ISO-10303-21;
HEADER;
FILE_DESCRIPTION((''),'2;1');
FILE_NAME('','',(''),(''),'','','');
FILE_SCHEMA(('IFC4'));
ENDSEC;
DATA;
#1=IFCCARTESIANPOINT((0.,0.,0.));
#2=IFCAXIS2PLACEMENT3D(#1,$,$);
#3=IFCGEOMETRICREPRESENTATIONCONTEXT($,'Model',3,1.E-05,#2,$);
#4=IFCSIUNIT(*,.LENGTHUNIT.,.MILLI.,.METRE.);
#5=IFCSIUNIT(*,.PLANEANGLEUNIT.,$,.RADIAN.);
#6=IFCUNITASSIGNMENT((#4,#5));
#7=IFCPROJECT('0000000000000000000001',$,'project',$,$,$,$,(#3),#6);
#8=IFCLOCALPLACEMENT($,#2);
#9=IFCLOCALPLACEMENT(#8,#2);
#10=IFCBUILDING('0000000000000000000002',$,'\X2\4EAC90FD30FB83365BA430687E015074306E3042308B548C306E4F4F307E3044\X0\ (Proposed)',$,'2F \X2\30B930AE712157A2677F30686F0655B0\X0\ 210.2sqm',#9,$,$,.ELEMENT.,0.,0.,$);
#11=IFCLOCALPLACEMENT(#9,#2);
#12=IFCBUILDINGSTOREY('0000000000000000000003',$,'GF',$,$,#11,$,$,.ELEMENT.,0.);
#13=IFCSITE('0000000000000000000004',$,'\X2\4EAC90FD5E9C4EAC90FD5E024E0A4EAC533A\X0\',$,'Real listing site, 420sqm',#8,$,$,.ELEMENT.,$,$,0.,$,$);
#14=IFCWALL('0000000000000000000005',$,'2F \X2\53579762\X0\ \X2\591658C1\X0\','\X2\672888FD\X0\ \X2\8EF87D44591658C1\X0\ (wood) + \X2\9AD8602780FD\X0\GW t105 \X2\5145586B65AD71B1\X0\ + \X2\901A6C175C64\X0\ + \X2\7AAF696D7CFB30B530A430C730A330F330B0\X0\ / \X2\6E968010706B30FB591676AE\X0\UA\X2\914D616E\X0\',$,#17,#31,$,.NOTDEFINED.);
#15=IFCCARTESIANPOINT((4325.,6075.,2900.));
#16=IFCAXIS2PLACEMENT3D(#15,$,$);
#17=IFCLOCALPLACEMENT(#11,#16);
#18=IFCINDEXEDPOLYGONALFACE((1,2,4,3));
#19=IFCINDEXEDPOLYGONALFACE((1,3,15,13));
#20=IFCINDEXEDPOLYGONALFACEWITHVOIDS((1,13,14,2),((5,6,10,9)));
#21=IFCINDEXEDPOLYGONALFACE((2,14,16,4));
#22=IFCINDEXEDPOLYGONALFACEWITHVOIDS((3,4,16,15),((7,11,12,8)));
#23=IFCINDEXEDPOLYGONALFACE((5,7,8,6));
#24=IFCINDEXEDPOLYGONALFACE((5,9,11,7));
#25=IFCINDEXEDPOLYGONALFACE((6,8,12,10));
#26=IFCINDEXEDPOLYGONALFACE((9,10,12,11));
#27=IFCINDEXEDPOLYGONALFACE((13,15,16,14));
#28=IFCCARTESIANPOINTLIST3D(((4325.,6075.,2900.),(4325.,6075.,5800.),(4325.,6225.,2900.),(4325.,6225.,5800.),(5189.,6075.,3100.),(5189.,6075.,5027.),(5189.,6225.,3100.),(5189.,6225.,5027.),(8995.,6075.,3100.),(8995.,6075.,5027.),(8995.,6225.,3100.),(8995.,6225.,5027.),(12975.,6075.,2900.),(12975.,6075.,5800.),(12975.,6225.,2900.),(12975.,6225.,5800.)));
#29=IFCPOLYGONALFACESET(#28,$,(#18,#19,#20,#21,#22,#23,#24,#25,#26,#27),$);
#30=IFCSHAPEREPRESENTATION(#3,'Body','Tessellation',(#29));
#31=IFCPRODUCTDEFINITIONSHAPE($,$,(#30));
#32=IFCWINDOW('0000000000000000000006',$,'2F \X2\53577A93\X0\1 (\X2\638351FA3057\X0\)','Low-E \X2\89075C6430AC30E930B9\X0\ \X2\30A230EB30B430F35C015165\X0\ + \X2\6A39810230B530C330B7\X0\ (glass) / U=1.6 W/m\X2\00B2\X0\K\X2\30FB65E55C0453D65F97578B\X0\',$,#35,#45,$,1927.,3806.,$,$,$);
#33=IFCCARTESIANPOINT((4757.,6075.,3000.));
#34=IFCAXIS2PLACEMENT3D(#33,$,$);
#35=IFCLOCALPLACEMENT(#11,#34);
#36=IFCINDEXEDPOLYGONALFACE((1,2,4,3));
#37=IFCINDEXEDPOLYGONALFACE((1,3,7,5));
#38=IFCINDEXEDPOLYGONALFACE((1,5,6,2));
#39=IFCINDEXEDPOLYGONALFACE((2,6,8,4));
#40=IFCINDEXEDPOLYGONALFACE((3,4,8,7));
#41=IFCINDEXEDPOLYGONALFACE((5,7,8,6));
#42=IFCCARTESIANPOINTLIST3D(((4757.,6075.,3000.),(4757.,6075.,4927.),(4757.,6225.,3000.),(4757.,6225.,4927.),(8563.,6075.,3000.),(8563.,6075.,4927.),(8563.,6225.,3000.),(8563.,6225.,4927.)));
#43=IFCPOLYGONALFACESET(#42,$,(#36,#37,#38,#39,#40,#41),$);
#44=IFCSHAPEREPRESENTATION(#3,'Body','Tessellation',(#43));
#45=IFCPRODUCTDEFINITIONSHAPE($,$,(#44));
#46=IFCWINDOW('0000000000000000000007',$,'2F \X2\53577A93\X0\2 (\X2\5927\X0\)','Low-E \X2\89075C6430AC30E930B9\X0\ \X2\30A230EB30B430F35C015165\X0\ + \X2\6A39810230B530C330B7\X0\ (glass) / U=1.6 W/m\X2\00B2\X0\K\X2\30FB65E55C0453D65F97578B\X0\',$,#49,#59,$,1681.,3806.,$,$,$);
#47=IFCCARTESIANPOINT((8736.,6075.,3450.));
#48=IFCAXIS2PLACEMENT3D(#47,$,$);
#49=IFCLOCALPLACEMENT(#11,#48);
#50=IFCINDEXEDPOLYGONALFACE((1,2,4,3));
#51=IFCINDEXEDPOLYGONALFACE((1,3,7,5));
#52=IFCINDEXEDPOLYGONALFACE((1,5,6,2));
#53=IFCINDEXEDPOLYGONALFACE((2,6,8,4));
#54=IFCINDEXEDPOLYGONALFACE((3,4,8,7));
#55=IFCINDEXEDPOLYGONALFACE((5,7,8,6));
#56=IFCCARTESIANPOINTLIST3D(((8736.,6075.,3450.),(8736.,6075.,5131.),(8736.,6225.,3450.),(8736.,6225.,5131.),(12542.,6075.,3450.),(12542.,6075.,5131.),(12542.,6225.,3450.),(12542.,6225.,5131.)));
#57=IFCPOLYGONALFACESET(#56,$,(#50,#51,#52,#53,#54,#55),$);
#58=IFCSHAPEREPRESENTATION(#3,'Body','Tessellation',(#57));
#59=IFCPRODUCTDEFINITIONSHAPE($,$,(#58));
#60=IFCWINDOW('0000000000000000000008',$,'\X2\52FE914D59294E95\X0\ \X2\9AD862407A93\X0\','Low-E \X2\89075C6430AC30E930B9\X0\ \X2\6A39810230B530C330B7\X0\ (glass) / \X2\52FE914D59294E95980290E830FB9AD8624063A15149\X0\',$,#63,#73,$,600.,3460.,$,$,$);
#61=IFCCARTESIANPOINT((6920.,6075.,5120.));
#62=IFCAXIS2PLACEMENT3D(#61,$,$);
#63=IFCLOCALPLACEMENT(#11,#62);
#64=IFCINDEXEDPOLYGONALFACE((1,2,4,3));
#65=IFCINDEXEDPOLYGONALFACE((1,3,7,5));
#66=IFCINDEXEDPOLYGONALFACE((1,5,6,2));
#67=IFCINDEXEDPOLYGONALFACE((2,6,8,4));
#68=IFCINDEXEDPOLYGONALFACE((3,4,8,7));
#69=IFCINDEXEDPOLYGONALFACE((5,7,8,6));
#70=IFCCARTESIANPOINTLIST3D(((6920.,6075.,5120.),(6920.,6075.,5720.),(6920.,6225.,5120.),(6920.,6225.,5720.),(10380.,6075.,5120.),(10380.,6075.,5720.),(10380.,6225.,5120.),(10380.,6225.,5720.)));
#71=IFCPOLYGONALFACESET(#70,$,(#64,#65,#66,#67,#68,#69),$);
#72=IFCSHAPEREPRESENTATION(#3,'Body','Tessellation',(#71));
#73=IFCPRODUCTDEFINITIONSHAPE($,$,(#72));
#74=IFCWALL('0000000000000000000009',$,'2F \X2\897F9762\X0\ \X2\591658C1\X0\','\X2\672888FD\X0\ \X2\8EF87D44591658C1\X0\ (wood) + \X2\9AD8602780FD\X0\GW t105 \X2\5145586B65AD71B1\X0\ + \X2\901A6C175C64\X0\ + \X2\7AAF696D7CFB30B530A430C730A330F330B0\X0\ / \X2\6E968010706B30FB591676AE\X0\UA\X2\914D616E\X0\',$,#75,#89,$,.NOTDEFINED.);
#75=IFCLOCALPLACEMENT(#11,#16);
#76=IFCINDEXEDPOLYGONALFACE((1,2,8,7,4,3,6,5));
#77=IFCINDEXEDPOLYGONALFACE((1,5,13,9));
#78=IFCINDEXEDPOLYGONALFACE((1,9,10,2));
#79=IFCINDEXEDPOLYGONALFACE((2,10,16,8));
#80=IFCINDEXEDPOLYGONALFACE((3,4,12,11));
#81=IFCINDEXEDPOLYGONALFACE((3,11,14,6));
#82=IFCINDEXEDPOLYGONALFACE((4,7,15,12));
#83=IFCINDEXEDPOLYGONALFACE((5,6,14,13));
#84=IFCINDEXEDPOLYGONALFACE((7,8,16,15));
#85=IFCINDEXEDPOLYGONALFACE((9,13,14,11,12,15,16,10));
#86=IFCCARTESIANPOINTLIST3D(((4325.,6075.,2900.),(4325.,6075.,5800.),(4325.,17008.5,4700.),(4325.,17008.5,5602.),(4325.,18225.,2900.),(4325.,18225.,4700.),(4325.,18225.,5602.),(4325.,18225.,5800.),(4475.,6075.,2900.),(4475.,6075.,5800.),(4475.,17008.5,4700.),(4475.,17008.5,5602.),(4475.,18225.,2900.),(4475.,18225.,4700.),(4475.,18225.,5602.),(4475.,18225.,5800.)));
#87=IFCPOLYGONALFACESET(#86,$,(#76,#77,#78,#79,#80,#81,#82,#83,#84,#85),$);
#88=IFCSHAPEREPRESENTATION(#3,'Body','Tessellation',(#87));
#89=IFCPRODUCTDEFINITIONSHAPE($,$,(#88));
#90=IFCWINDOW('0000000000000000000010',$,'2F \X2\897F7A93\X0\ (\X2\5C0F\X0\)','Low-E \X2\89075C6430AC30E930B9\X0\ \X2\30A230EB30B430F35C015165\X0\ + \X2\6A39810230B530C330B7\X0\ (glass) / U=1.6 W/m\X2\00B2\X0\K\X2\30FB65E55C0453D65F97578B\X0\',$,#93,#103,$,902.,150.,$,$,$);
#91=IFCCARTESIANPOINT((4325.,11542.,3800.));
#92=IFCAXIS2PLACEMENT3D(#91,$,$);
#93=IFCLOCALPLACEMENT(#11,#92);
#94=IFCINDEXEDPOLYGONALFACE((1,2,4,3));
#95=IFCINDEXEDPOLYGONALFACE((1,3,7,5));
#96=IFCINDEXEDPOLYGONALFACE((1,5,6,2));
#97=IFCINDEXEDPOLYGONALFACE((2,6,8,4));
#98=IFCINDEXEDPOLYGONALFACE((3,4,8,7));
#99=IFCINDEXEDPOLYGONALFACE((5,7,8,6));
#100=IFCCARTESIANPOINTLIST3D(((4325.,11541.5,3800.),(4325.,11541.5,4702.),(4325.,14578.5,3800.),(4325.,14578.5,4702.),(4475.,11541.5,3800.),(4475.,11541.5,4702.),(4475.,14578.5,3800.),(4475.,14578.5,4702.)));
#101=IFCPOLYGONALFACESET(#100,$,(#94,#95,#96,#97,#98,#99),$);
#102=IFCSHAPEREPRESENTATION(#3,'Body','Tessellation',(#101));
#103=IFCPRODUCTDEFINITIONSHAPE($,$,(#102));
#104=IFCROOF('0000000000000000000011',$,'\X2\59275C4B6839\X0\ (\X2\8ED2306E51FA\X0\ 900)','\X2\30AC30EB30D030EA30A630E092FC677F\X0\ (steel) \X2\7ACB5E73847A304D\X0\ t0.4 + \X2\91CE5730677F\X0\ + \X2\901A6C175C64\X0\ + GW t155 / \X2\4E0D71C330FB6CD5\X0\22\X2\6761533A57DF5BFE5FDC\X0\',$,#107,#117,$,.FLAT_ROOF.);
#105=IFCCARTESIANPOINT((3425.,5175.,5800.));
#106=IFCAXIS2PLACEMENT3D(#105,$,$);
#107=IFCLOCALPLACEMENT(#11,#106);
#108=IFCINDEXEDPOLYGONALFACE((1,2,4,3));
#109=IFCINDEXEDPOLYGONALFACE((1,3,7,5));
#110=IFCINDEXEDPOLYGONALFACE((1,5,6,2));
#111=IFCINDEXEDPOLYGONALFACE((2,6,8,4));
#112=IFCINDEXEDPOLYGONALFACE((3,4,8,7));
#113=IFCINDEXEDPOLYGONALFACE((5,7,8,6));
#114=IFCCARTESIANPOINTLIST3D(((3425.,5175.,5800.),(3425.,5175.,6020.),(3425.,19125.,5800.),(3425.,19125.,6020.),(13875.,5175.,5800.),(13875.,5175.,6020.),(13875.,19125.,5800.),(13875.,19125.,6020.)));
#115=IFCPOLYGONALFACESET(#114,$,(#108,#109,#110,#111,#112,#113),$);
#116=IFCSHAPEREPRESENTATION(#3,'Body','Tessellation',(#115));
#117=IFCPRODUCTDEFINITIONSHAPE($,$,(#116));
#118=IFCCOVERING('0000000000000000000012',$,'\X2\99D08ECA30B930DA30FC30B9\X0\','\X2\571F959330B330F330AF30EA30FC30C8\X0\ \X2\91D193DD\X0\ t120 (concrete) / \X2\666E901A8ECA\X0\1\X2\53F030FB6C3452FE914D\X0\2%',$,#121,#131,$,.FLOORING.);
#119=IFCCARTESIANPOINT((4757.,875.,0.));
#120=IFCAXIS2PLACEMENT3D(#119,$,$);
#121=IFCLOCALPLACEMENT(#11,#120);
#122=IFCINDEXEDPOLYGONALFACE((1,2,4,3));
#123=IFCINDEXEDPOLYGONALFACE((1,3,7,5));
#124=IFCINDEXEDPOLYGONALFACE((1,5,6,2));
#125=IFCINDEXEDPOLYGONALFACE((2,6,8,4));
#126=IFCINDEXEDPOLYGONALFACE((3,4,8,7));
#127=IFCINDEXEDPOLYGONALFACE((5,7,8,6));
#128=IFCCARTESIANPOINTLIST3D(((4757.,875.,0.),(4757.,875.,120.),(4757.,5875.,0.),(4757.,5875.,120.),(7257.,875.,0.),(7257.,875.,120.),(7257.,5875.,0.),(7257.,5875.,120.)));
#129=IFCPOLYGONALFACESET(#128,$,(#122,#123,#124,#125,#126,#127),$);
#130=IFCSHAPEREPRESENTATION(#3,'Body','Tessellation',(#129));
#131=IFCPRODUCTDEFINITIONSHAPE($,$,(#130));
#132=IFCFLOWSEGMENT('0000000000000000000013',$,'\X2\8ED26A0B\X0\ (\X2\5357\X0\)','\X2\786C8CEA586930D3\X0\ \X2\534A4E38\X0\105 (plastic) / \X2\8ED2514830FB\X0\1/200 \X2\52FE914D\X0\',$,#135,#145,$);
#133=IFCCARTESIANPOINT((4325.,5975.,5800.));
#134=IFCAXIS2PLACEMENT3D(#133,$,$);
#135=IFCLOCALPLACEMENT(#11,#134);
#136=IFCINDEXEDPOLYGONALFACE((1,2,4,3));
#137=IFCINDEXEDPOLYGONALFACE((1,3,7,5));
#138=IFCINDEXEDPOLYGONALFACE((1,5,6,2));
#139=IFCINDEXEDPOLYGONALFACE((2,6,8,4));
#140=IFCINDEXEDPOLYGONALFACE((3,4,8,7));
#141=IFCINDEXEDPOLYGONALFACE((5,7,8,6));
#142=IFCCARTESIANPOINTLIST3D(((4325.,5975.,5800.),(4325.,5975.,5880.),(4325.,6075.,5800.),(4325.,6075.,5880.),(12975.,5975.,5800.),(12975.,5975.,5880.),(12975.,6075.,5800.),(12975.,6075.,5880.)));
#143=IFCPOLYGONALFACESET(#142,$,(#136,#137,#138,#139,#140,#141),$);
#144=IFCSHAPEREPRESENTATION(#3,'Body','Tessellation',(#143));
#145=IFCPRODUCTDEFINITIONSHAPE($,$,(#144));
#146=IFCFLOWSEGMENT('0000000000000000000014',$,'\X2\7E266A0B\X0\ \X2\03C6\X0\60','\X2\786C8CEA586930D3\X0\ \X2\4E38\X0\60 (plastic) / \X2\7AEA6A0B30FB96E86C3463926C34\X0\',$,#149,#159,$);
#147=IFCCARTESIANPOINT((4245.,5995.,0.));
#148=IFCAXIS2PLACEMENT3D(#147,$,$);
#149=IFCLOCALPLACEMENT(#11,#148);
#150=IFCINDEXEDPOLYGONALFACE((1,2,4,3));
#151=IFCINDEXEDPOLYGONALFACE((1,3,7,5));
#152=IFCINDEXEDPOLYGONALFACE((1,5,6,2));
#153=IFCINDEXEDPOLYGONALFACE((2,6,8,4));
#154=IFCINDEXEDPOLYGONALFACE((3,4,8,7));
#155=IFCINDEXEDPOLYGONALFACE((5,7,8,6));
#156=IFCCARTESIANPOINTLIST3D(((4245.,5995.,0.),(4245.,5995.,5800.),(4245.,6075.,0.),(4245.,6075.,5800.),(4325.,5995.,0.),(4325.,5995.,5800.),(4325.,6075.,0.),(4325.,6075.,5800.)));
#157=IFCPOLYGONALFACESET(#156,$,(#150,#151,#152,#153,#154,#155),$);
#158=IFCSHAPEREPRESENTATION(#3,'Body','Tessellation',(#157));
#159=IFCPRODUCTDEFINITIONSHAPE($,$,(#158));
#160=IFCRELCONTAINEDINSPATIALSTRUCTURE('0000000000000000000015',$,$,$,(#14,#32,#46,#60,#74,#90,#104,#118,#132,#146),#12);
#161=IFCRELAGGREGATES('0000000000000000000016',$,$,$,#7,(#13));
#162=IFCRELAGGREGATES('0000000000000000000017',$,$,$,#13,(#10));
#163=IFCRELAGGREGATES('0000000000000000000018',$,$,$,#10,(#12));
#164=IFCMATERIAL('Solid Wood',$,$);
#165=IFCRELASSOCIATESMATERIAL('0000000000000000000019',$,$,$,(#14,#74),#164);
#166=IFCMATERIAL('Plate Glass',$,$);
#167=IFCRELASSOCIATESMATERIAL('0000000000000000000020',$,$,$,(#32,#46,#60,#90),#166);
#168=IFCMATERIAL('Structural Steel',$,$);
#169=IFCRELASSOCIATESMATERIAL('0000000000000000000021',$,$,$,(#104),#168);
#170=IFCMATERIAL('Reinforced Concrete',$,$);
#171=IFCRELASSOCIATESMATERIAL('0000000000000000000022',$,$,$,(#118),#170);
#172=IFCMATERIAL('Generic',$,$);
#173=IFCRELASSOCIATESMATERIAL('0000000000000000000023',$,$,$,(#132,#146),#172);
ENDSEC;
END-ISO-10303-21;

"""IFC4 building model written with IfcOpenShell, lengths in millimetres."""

from ifc_helpers import new_model, si_unit, frame, frame_2d, origin, place, context, project, spatial, rectangle, extrude, material, element, fill, save


model = new_model("IFC4")

# Units and contexts
model_context = context("Model", 3, precision=1e-05, world=origin())
ifc_project = project(units=[si_unit("LENGTHUNIT", "METRE", prefix="MILLI"), si_unit("PLANEANGLEUNIT", "RADIAN")], contexts=[model_context])

# Site, building, storey
site_placement = place(None, origin())
site = spatial("IfcSite", under=ifc_project, at=site_placement, Name="京都府京都市上京区", ObjectType="Real listing site, 420sqm", CompositionType="ELEMENT", RefElevation=0.0)
building_placement = place(site_placement, origin())
building = spatial("IfcBuilding", under=site, at=building_placement, Name="京都・茶室と縁側のある和の住まい (Proposed)", ObjectType="2F スギ無垢板と漆喰 210.2sqm", CompositionType="ELEMENT", ElevationOfRefHeight=0.0, ElevationOfTerrain=0.0)
storey_placement = place(building_placement, origin())
storey = spatial("IfcBuildingStorey", under=building, at=storey_placement, Name="GF", CompositionType="ELEMENT", Elevation=0.0)

# Shared definitions
ifc_material_1 = material(Name="Solid Wood")

# Shared definitions
ifc_material_2 = material(Name="Reinforced Concrete")

# Shared definitions
ifc_material_3 = material(Name="Plate Glass")

# Wall, openings, windows
wall_1_placement = place(storey_placement, frame((4325.0, 6075.0, 2900.0)))
wall_1 = element("IfcWall", 1, at=wall_1_placement, inside=storey, material=ifc_material_1, Name="2F 南面 外壁", Description="木製 軸組外壁 (wood) + 高性能GW t105 充填断熱 + 通気層 + 窯業系サイディング / 準耐火・外皮UA配慮", PredefinedType="NOTDEFINED", context=model_context, shape_type="SweptSolid", body=[
    extrude(rectangle(XDim=8650.0, YDim=150.0, at=frame_2d((4325.0, 75.0))), frame((4325.0, 6075.0, 2900.0)), (0.0, 0.0, 1.0), 2900.0),
])
opening_1_placement = place(storey_placement, frame((4757.0, 6075.0, 3000.0)))
opening_1 = element("IfcOpeningElement", 2, at=opening_1_placement, cuts=wall_1, PredefinedType="NOTDEFINED", context=model_context, shape_type="SweptSolid", body=[
    extrude(rectangle(XDim=3806.0, YDim=150.0, at=frame_2d((1903.0, 75.0))), frame((4757.0, 6075.0, 3000.0)), (0.0, 0.0, 1.0), 1927.0),
])
opening_2_placement = place(storey_placement, frame((8736.0, 6075.0, 3450.0)))
opening_2 = element("IfcOpeningElement", 3, at=opening_2_placement, cuts=wall_1, PredefinedType="NOTDEFINED", context=model_context, shape_type="SweptSolid", body=[
    extrude(rectangle(XDim=3806.0, YDim=150.0, at=frame_2d((1903.0, 75.0))), frame((8736.0, 6075.0, 3450.0)), (0.0, 0.0, 1.0), 1681.0),
])
opening_3_placement = place(storey_placement, frame((6920.0, 6075.0, 5120.0)))
opening_3 = element("IfcOpeningElement", 4, at=opening_3_placement, cuts=wall_1, PredefinedType="NOTDEFINED", context=model_context, shape_type="SweptSolid", body=[
    extrude(rectangle(XDim=3460.0, YDim=150.0, at=frame_2d((1730.0, 75.0))), frame((6920.0, 6075.0, 5120.0)), (0.0, 0.0, 1.0), 600.0),
])
window_1_placement = place(storey_placement, frame((4757.0, 6075.0, 3000.0)))
window_1 = element("IfcWindow", 5, at=window_1_placement, inside=storey, material=ifc_material_3, Name="2F 南窓1 (掃出し)", Description="Low-E 複層ガラス アルゴン封入 + 樹脂サッシ (glass) / U=1.6 W/m²K・日射取得型", OverallHeight=1927.0, OverallWidth=3806.0, context=model_context, shape_type="SweptSolid", body=[
    extrude(rectangle(XDim=3806.0, YDim=150.0, at=frame_2d((1903.0, 75.0))), frame((4757.0, 6075.0, 3000.0)), (0.0, 0.0, 1.0), 1927.0),
])
fill(opening_1, window_1)
window_2_placement = place(storey_placement, frame((8736.0, 6075.0, 3450.0)))
window_2 = element("IfcWindow", 6, at=window_2_placement, inside=storey, material=ifc_material_3, Name="2F 南窓2 (大)", Description="Low-E 複層ガラス アルゴン封入 + 樹脂サッシ (glass) / U=1.6 W/m²K・日射取得型", OverallHeight=1681.0, OverallWidth=3806.0, context=model_context, shape_type="SweptSolid", body=[
    extrude(rectangle(XDim=3806.0, YDim=150.0, at=frame_2d((1903.0, 75.0))), frame((8736.0, 6075.0, 3450.0)), (0.0, 0.0, 1.0), 1681.0),
])
fill(opening_2, window_2)
window_3_placement = place(storey_placement, frame((6920.0, 6075.0, 5120.0)))
window_3 = element("IfcWindow", 7, at=window_3_placement, inside=storey, material=ifc_material_3, Name="勾配天井 高所窓", Description="Low-E 複層ガラス 樹脂サッシ (glass) / 勾配天井頂部・高所採光", OverallHeight=600.0, OverallWidth=3460.0, context=model_context, shape_type="SweptSolid", body=[
    extrude(rectangle(XDim=3460.0, YDim=150.0, at=frame_2d((1730.0, 75.0))), frame((6920.0, 6075.0, 5120.0)), (0.0, 0.0, 1.0), 600.0),
])
fill(opening_3, window_3)

# Wall, opening, window
wall_2_placement = place(storey_placement, frame((4325.0, 6075.0, 2900.0)))
wall_2 = element("IfcWall", 8, at=wall_2_placement, inside=storey, material=ifc_material_1, Name="2F 西面 外壁", Description="木製 軸組外壁 (wood) + 高性能GW t105 充填断熱 + 通気層 + 窯業系サイディング / 準耐火・外皮UA配慮", PredefinedType="NOTDEFINED", context=model_context, shape_type="SweptSolid", body=[
    extrude(rectangle(XDim=150.0, YDim=12150.0, at=frame_2d((75.0, 6075.0))), frame((4325.0, 6075.0, 2900.0)), (0.0, 0.0, 1.0), 2900.0),
])
opening_4_placement = place(storey_placement, frame((4325.0, 11542.0, 3800.0)))
opening_4 = element("IfcOpeningElement", 9, at=opening_4_placement, cuts=wall_2, PredefinedType="NOTDEFINED", context=model_context, shape_type="SweptSolid", body=[
    extrude(rectangle(XDim=150.0, YDim=3037.0, at=frame_2d((75.0, 1518.0))), frame((4325.0, 11542.0, 3800.0)), (0.0, 0.0, 1.0), 902.0),
])
window_4_placement = place(storey_placement, frame((4325.0, 11542.0, 3800.0)))
window_4 = element("IfcWindow", 10, at=window_4_placement, inside=storey, material=ifc_material_3, Name="2F 西窓 (小)", Description="Low-E 複層ガラス アルゴン封入 + 樹脂サッシ (glass) / U=1.6 W/m²K・日射取得型", OverallHeight=902.0, OverallWidth=150.0, context=model_context, shape_type="SweptSolid", body=[
    extrude(rectangle(XDim=150.0, YDim=3037.0, at=frame_2d((75.0, 1518.0))), frame((4325.0, 11542.0, 3800.0)), (0.0, 0.0, 1.0), 902.0),
])
fill(opening_4, window_4)

# Roof
ifc_material_4 = material(Name="Structural Steel")
roof_placement = place(storey_placement, frame((3425.0, 5175.0, 5800.0)))
element("IfcRoof", 11, at=roof_placement, inside=storey, material=ifc_material_4, Name="大屋根 (軒の出 900)", Description="ガルバリウム鋼板 (steel) 立平葺き t0.4 + 野地板 + 通気層 + GW t155 / 不燃・法22条区域対応", PredefinedType="FLAT_ROOF", context=model_context, shape_type="SweptSolid", body=[
    extrude(rectangle(XDim=10450.0, YDim=13950.0, at=frame_2d((5225.0, 6975.0))), frame((3425.0, 5175.0, 5800.0)), (0.0, 0.0, 1.0), 220.0),
])

# Covering
covering_placement = place(storey_placement, frame((4757.0, 875.0, 0.0)))
element("IfcCovering", 12, at=covering_placement, inside=storey, material=ifc_material_2, Name="駐車スペース", Description="土間コンクリート 金鏝 t120 (concrete) / 普通車1台・水勾配2%", PredefinedType="FLOORING", context=model_context, shape_type="SweptSolid", body=[
    extrude(rectangle(XDim=2500.0, YDim=5000.0, at=frame_2d((1250.0, 2500.0))), frame((4757.0, 875.0, 0.0)), (0.0, 0.0, 1.0), 120.0),
])

# Flow segments
ifc_material_5 = material(Name="Generic")
flow_segment_1_placement = place(storey_placement, frame((4325.0, 5975.0, 5800.0)))
element("IfcFlowSegment", 13, at=flow_segment_1_placement, inside=storey, material=ifc_material_5, Name="軒樋 (南)", Description="硬質塩ビ 半丸105 (plastic) / 軒先・1/200 勾配", context=model_context, shape_type="SweptSolid", body=[
    extrude(rectangle(XDim=8650.0, YDim=100.0, at=frame_2d((4325.0, 50.0))), frame((4325.0, 5975.0, 5800.0)), (0.0, 0.0, 1.0), 80.0),
])
flow_segment_2_placement = place(storey_placement, frame((4245.0, 5995.0, 0.0)))
element("IfcFlowSegment", 14, at=flow_segment_2_placement, inside=storey, material=ifc_material_5, Name="縦樋 φ60", Description="硬質塩ビ 丸60 (plastic) / 竪樋・雨水排水", context=model_context, shape_type="SweptSolid", body=[
    extrude(rectangle(XDim=80.0, YDim=80.0, at=frame_2d((40.0, 40.0))), frame((4245.0, 5995.0, 0.0)), (0.0, 0.0, 1.0), 5800.0),
])

save(model, "model.ifc")
